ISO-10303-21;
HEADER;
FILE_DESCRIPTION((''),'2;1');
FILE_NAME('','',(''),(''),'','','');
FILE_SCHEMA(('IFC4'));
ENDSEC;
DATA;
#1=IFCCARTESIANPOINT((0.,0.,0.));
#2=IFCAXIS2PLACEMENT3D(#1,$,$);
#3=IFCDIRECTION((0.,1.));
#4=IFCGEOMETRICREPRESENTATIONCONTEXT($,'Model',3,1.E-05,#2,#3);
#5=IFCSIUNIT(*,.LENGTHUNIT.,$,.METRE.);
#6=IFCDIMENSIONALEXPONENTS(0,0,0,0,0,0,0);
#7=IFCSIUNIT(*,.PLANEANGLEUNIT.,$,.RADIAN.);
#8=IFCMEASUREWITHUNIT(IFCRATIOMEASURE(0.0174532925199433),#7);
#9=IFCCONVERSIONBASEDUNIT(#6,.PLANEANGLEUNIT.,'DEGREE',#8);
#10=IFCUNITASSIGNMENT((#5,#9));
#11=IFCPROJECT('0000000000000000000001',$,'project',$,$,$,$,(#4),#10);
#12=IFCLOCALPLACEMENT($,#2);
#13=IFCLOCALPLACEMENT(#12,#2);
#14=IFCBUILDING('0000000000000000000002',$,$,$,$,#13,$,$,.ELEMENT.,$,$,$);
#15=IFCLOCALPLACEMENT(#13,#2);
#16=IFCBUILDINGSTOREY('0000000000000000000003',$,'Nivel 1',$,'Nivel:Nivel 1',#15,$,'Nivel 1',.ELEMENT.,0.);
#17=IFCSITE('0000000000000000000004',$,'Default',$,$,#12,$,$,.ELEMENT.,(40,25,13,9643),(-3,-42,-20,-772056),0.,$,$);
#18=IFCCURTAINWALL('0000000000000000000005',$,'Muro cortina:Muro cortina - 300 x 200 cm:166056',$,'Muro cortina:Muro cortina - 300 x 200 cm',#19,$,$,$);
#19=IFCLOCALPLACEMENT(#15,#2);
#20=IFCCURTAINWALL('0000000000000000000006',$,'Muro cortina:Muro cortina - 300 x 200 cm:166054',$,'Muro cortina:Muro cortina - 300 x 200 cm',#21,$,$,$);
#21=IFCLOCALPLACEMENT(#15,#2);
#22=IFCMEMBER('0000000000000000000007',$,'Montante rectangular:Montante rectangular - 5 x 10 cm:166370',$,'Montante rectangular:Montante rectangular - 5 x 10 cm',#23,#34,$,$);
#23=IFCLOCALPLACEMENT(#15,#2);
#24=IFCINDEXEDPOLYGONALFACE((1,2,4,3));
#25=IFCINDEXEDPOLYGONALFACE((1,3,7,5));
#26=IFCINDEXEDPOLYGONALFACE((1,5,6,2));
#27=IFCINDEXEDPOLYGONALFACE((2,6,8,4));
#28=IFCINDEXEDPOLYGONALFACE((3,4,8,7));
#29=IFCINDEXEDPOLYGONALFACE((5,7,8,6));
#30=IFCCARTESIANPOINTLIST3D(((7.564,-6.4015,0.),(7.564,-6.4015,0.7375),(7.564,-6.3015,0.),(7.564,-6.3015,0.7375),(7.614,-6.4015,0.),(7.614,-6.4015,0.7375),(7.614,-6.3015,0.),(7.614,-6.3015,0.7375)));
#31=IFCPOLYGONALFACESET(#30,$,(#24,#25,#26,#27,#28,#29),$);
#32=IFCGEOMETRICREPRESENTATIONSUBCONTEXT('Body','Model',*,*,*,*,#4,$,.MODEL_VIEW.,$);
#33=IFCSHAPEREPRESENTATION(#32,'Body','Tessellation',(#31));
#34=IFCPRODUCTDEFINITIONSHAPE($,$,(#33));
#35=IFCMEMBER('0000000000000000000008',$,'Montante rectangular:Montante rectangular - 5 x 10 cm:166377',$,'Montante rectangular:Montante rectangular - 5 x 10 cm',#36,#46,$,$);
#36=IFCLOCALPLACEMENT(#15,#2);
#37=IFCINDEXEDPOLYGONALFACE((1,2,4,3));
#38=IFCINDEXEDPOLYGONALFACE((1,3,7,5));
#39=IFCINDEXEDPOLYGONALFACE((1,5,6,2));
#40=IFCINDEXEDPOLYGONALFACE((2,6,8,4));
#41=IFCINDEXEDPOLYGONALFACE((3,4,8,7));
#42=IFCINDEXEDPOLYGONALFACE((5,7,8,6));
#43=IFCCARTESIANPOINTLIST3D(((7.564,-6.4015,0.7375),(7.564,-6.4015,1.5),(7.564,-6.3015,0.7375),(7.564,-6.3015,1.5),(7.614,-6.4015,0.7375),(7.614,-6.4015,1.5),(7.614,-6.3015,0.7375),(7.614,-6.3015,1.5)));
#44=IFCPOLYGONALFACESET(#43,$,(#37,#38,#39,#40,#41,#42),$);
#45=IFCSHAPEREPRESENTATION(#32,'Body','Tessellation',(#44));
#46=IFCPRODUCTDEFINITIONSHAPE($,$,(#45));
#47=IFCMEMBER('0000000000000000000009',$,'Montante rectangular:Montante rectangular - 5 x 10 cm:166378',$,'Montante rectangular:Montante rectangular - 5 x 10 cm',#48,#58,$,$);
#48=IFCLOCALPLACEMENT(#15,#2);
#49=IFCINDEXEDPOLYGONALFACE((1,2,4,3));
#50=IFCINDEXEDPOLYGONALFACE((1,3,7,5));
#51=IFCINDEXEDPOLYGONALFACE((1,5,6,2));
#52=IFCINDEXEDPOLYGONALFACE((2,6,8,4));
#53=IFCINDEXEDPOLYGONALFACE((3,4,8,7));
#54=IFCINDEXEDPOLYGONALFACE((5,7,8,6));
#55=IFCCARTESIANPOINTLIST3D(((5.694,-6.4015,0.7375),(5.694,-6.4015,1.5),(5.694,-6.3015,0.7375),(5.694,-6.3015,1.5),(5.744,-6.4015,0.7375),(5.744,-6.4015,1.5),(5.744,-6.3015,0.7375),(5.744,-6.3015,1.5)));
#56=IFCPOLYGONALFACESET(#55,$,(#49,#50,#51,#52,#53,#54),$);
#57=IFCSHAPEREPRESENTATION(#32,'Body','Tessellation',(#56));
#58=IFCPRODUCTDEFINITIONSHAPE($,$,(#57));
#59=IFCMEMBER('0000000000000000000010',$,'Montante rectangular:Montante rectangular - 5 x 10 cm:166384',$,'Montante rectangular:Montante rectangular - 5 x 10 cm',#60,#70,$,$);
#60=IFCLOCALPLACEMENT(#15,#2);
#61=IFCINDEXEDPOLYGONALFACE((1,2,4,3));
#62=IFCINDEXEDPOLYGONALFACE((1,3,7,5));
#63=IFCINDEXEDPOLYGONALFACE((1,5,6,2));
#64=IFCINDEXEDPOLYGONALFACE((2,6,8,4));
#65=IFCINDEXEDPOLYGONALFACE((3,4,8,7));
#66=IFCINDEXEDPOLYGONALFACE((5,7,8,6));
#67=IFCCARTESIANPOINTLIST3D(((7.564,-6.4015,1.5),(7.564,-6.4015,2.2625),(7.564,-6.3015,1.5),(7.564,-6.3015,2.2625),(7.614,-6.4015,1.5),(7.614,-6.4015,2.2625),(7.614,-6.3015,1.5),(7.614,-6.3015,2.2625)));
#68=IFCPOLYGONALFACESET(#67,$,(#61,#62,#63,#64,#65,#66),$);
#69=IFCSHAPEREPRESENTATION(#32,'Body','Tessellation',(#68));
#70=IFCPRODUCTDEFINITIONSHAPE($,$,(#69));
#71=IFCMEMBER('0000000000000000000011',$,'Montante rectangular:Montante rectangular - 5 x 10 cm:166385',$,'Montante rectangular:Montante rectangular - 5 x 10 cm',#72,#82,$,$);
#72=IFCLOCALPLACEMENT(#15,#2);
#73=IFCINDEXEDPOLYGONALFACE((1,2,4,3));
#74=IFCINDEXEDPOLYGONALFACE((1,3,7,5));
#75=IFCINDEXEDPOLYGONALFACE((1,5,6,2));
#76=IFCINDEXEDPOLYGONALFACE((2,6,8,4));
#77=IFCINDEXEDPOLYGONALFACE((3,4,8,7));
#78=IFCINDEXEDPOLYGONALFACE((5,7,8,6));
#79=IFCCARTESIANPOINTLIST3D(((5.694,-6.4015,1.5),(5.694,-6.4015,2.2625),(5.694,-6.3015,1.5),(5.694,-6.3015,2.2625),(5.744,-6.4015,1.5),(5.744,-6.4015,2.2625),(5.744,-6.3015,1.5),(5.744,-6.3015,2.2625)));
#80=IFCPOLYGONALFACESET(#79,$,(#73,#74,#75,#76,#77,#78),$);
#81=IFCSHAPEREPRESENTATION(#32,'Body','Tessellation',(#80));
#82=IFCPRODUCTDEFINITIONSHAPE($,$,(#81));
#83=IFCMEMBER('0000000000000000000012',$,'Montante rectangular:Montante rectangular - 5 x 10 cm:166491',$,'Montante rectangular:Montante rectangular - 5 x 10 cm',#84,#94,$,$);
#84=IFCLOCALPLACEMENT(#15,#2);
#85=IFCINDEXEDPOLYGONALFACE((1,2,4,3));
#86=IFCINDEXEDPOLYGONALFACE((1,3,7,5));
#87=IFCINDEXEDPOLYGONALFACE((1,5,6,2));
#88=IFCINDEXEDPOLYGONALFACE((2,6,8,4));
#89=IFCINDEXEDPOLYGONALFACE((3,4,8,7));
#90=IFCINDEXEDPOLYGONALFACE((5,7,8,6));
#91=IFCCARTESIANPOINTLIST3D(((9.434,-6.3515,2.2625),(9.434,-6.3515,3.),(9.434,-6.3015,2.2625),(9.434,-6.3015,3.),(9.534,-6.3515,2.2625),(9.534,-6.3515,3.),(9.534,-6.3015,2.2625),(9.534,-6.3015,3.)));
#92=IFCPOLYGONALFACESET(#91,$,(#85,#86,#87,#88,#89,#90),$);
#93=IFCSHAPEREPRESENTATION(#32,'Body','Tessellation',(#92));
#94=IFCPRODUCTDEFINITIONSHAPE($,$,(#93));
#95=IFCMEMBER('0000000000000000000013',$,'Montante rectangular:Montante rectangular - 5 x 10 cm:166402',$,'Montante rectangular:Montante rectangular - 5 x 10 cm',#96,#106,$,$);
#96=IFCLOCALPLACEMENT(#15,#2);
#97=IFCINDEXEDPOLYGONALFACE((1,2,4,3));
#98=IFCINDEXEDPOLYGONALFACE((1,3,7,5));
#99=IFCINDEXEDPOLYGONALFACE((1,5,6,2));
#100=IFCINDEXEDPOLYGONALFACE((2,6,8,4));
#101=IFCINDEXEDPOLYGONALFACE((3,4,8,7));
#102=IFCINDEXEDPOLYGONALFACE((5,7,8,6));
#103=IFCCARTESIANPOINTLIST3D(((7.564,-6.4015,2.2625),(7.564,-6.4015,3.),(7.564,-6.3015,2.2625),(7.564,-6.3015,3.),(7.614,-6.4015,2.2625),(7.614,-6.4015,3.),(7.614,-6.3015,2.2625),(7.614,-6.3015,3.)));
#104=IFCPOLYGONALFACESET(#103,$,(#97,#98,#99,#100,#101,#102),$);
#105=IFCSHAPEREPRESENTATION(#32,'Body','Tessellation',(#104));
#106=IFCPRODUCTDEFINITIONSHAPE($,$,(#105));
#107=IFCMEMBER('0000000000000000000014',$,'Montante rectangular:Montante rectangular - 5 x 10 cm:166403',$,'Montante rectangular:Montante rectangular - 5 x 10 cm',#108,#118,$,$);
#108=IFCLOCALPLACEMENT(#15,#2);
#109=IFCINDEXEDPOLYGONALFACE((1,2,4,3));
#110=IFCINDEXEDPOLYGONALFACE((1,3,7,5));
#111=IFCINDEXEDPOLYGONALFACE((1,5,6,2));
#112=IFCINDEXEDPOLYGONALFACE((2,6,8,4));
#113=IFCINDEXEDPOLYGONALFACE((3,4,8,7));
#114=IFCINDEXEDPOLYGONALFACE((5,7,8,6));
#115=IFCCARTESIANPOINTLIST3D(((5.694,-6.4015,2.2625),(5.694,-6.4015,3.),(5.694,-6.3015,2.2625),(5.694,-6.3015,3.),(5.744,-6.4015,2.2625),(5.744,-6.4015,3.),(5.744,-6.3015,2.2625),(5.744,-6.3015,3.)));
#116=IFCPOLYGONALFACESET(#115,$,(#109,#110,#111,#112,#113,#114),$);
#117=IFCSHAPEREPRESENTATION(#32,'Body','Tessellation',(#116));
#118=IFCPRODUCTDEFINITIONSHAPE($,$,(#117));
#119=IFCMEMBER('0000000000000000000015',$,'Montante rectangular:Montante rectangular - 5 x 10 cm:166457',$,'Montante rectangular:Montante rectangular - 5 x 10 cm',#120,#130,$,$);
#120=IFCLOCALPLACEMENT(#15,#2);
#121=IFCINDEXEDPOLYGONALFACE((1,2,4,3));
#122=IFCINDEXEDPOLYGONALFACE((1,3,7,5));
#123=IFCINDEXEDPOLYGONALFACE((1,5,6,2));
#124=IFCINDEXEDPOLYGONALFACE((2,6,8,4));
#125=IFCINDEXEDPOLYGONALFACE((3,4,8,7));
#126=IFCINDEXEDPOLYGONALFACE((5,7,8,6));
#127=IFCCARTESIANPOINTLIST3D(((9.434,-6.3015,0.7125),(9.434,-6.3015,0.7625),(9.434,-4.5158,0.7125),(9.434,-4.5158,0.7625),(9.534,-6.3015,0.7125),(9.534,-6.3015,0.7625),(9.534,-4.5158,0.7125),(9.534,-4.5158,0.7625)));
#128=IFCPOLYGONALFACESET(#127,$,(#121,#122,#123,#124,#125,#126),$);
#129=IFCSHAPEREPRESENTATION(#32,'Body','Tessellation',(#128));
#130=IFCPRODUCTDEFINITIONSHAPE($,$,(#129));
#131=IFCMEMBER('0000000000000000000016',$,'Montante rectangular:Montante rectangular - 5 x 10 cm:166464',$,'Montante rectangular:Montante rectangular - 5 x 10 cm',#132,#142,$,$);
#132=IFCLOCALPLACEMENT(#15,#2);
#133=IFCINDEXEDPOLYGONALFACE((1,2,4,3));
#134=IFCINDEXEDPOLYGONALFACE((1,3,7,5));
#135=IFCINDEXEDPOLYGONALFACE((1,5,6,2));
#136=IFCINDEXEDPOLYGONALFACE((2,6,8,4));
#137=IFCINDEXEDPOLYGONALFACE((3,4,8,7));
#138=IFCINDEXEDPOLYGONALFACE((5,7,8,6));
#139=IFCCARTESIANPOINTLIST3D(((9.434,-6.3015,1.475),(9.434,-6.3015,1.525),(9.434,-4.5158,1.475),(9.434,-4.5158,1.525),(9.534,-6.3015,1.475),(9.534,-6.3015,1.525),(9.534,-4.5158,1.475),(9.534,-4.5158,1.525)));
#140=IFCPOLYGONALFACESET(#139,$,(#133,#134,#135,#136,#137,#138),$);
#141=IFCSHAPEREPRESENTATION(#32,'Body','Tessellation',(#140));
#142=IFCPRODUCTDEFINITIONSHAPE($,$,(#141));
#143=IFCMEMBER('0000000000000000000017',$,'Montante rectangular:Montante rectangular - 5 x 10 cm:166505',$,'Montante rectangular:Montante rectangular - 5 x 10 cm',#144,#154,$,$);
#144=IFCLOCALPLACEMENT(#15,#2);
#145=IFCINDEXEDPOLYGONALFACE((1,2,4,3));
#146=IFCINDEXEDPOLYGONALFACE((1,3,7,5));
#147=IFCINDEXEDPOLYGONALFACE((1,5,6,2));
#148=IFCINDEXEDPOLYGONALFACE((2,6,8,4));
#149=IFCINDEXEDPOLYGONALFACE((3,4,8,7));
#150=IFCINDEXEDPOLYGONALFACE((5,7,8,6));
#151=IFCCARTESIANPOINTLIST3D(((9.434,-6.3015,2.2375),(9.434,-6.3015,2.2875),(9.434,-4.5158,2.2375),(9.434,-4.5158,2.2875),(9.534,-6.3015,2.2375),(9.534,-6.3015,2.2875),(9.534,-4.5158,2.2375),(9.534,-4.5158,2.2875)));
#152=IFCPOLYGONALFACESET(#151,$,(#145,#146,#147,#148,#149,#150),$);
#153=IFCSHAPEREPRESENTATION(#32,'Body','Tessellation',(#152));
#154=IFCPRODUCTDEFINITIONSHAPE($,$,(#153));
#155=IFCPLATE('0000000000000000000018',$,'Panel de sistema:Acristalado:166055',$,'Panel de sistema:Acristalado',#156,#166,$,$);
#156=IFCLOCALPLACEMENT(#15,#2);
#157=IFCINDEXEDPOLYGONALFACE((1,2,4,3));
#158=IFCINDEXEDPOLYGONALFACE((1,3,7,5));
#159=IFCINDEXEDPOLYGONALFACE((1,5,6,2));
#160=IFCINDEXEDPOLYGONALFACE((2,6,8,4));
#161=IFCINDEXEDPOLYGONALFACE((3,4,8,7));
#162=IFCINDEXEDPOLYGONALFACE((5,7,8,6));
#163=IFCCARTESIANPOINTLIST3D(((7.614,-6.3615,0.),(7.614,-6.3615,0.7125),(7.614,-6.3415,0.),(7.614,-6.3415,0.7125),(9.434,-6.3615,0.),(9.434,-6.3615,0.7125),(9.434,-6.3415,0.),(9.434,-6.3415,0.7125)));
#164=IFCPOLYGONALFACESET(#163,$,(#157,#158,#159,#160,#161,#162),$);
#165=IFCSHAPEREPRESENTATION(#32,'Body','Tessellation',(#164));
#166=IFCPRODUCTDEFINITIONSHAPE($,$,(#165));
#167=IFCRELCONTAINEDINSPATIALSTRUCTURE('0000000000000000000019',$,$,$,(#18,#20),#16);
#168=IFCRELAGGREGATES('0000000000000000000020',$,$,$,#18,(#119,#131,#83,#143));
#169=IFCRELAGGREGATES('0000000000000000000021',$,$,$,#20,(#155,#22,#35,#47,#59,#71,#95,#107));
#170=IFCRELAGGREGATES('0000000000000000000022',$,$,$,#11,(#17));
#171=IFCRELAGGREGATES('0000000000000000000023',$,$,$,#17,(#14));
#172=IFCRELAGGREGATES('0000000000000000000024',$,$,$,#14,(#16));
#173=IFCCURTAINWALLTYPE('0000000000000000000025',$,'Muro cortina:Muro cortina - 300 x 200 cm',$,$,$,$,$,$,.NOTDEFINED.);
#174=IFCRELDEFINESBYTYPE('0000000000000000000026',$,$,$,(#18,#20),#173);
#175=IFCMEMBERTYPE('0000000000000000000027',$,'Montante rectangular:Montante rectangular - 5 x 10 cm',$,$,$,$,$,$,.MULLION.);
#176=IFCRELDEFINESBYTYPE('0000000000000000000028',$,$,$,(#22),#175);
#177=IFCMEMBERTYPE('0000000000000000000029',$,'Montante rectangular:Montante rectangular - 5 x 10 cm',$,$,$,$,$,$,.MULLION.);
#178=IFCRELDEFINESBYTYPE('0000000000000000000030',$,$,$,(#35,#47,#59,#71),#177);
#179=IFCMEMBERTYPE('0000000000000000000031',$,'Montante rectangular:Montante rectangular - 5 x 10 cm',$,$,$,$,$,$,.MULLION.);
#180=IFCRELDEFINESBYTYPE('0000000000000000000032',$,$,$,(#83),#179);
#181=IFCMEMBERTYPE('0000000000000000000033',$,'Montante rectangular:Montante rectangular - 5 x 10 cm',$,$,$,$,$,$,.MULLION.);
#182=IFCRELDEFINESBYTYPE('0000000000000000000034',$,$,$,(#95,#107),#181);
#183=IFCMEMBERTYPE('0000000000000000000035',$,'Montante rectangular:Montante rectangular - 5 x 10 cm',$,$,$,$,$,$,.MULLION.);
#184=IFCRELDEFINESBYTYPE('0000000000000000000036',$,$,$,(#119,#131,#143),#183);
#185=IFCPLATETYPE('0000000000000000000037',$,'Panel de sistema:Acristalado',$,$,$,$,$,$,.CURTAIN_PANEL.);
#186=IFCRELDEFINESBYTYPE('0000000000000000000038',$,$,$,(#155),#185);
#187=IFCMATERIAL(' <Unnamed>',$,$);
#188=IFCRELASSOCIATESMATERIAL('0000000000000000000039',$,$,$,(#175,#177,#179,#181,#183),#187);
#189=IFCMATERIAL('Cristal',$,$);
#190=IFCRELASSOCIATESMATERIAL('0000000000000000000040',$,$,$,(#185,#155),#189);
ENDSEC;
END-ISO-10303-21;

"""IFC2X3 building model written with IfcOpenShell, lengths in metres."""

from ifc_helpers import new_model, entity, si_unit, converted_unit, direction, frame, origin, origin_2d_with_axis, place, context, subcontext, project, spatial, rectangle, extrude, source, transform, mapped, material, type_object, type_shapes, element, aggregate, save


model = new_model("IFC2X3")

# Units and contexts
model_context = context("Model", 3, precision=1e-05, world=origin(), true_north=direction((0.0, 1.0)))
body_context = subcontext(model_context, "Body", "Model", "MODEL_VIEW")
ifc_project = project(units=[si_unit("LENGTHUNIT", "METRE"), converted_unit("PLANEANGLEUNIT", "DEGREE", entity("IfcRatioMeasure", 0.0174532925199433), si_unit("PLANEANGLEUNIT", "RADIAN"), dimensions=[0, 0, 0, 0, 0, 0, 0])], contexts=[model_context])

# Site, building, storey
site_placement = place(None, origin())
site = spatial("IfcSite", under=ifc_project, at=site_placement, Name="Default", CompositionType="ELEMENT", RefLatitude=(40, 25, 13, 9643), RefLongitude=(-3, -42, -20, -772056), RefElevation=0.0)
building_placement = place(site_placement, origin())
building = spatial("IfcBuilding", under=site, at=building_placement, CompositionType="ELEMENT")
storey_placement = place(building_placement, origin())
storey = spatial("IfcBuildingStorey", under=building, at=storey_placement, Name="Nivel 1", ObjectType="Nivel:Nivel 1", LongName="Nivel 1", CompositionType="ELEMENT", Elevation=0.0)

# Curtain walls, members
curtain_wall_type = type_object("IfcCurtainWallType", Name="Muro cortina:Muro cortina - 300 x 200 cm", PredefinedType="NOTDEFINED")
curtain_wall_1_placement = place(storey_placement, origin())
curtain_wall_1 = element("IfcCurtainWall", 1, at=curtain_wall_1_placement, inside=storey, type_object=curtain_wall_type, Name="Muro cortina:Muro cortina - 300 x 200 cm:166056", ObjectType="Muro cortina:Muro cortina - 300 x 200 cm")
ifc_material_1 = material(Name=" <Unnamed>")
curtain_wall_2_placement = place(storey_placement, origin())
curtain_wall_2 = element("IfcCurtainWall", 2, at=curtain_wall_2_placement, inside=storey, type_object=curtain_wall_type, Name="Muro cortina:Muro cortina - 300 x 200 cm:166054", ObjectType="Muro cortina:Muro cortina - 300 x 200 cm")
member_type_1 = type_object("IfcMemberType", Name="Montante rectangular:Montante rectangular - 5 x 10 cm", PredefinedType="MULLION", material=ifc_material_1)
shared_shape_1 = source(origin(), body_context, "Body", "SweptSolid", [
    extrude(rectangle(XDim=0.1, YDim=0.05, at=origin_2d_with_axis()), frame((0.0, 0.0, -0.7375), z_axis=(0.0, 0.0, 1.0), x_axis=(0.0, -1.0, 0.0)), (0.0, 0.0, 1.0), 0.7375),
])
type_shapes(member_type_1, [shared_shape_1])
member_1_placement = place(storey_placement, frame((7.589, -6.3515, 0.0), z_axis=(0.0, 0.0, -1.0), x_axis=(-1.0, 0.0, 0.0)))
member_1 = element("IfcMember", 3, at=member_1_placement, type_object=member_type_1, Name="Montante rectangular:Montante rectangular - 5 x 10 cm:166370", ObjectType="Montante rectangular:Montante rectangular - 5 x 10 cm", context=body_context, shape_type="MappedRepresentation", body=[
    mapped(shared_shape_1, transform((0.0, 0.0, 0.0), scale=1.0)),
])
member_type_2 = type_object("IfcMemberType", Name="Montante rectangular:Montante rectangular - 5 x 10 cm", PredefinedType="MULLION", material=ifc_material_1)
shared_shape_2 = source(origin(), body_context, "Body", "SweptSolid", [
    extrude(rectangle(XDim=0.1, YDim=0.05, at=origin_2d_with_axis()), frame((0.0, 0.0, -0.7625), z_axis=(0.0, 0.0, 1.0), x_axis=(0.0, -1.0, 0.0)), (0.0, 0.0, 1.0), 0.7625),
])
type_shapes(member_type_2, [shared_shape_2])
member_2_placement = place(storey_placement, frame((7.589, -6.3515, 0.7375), z_axis=(0.0, 0.0, -1.0), x_axis=(-1.0, 0.0, 0.0)))
member_2 = element("IfcMember", 4, at=member_2_placement, type_object=member_type_2, Name="Montante rectangular:Montante rectangular - 5 x 10 cm:166377", ObjectType="Montante rectangular:Montante rectangular - 5 x 10 cm", context=body_context, shape_type="MappedRepresentation", body=[
    mapped(shared_shape_2, transform((0.0, 0.0, 0.0), scale=1.0)),
])
member_3_placement = place(storey_placement, frame((5.719, -6.3515, 0.7375), z_axis=(0.0, 0.0, -1.0), x_axis=(-1.0, 0.0, 0.0)))
member_3 = element("IfcMember", 5, at=member_3_placement, type_object=member_type_2, Name="Montante rectangular:Montante rectangular - 5 x 10 cm:166378", ObjectType="Montante rectangular:Montante rectangular - 5 x 10 cm", context=body_context, shape_type="MappedRepresentation", body=[
    mapped(shared_shape_2, transform((0.0, 0.0, 0.0), scale=1.0)),
])
member_4_placement = place(storey_placement, frame((7.589, -6.3515, 1.5), z_axis=(0.0, 0.0, -1.0), x_axis=(-1.0, 0.0, 0.0)))
member_4 = element("IfcMember", 6, at=member_4_placement, type_object=member_type_2, Name="Montante rectangular:Montante rectangular - 5 x 10 cm:166384", ObjectType="Montante rectangular:Montante rectangular - 5 x 10 cm", context=body_context, shape_type="MappedRepresentation", body=[
    mapped(shared_shape_2, transform((0.0, 0.0, 0.0), scale=1.0)),
])
member_5_placement = place(storey_placement, frame((5.719, -6.3515, 1.5), z_axis=(0.0, 0.0, -1.0), x_axis=(-1.0, 0.0, 0.0)))
member_5 = element("IfcMember", 7, at=member_5_placement, type_object=member_type_2, Name="Montante rectangular:Montante rectangular - 5 x 10 cm:166385", ObjectType="Montante rectangular:Montante rectangular - 5 x 10 cm", context=body_context, shape_type="MappedRepresentation", body=[
    mapped(shared_shape_2, transform((0.0, 0.0, 0.0), scale=1.0)),
])

# Members
member_type_3 = type_object("IfcMemberType", Name="Montante rectangular:Montante rectangular - 5 x 10 cm", PredefinedType="MULLION", material=ifc_material_1)
shared_shape_3 = source(origin(), body_context, "Body", "SweptSolid", [
    extrude(rectangle(XDim=0.1, YDim=0.05, at=origin_2d_with_axis()), frame((-0.025, 0.0, -0.7375), z_axis=(0.0, 0.0, 1.0), x_axis=(0.0, -1.0, 0.0)), (0.0, 0.0, 1.0), 0.7375),
])
type_shapes(member_type_3, [shared_shape_3])
member_6_placement = place(storey_placement, frame((9.484, -6.3515, 2.2625), z_axis=(0.0, 0.0, -1.0), x_axis=(0.0, -1.0, 0.0)))
member_6 = element("IfcMember", 8, at=member_6_placement, type_object=member_type_3, Name="Montante rectangular:Montante rectangular - 5 x 10 cm:166491", ObjectType="Montante rectangular:Montante rectangular - 5 x 10 cm", context=body_context, shape_type="MappedRepresentation", body=[
    mapped(shared_shape_3, transform((0.0, 0.0, 0.0), scale=1.0)),
])
member_type_4 = type_object("IfcMemberType", Name="Montante rectangular:Montante rectangular - 5 x 10 cm", PredefinedType="MULLION", material=ifc_material_1)
shared_shape_4 = source(origin(), body_context, "Body", "SweptSolid", [
    extrude(rectangle(XDim=0.1, YDim=0.05, at=origin_2d_with_axis()), frame((0.0, 0.0, -0.7375), z_axis=(0.0, 0.0, 1.0), x_axis=(0.0, -1.0, 0.0)), (0.0, 0.0, 1.0), 0.7375),
])
type_shapes(member_type_4, [shared_shape_4])
member_7_placement = place(storey_placement, frame((7.589, -6.3515, 2.2625), z_axis=(0.0, 0.0, -1.0), x_axis=(-1.0, 0.0, 0.0)))
member_7 = element("IfcMember", 9, at=member_7_placement, type_object=member_type_4, Name="Montante rectangular:Montante rectangular - 5 x 10 cm:166402", ObjectType="Montante rectangular:Montante rectangular - 5 x 10 cm", context=body_context, shape_type="MappedRepresentation", body=[
    mapped(shared_shape_4, transform((0.0, 0.0, 0.0), scale=1.0)),
])
member_8_placement = place(storey_placement, frame((5.719, -6.3515, 2.2625), z_axis=(0.0, 0.0, -1.0), x_axis=(-1.0, 0.0, 0.0)))
member_8 = element("IfcMember", 10, at=member_8_placement, type_object=member_type_4, Name="Montante rectangular:Montante rectangular - 5 x 10 cm:166403", ObjectType="Montante rectangular:Montante rectangular - 5 x 10 cm", context=body_context, shape_type="MappedRepresentation", body=[
    mapped(shared_shape_4, transform((0.0, 0.0, 0.0), scale=1.0)),
])
member_type_5 = type_object("IfcMemberType", Name="Montante rectangular:Montante rectangular - 5 x 10 cm", PredefinedType="MULLION", material=ifc_material_1)
shared_shape_5 = source(origin(), body_context, "Body", "SweptSolid", [
    extrude(rectangle(XDim=0.1, YDim=0.05, at=origin_2d_with_axis()), frame((0.0, 0.0, -1.7857), z_axis=(0.0, 0.0, 1.0), x_axis=(0.0, -1.0, 0.0)), (0.0, 0.0, 1.0), 1.7857),
])
type_shapes(member_type_5, [shared_shape_5])
member_9_placement = place(storey_placement, frame((9.484, -6.3015, 0.7375), z_axis=(0.0, -1.0, 0.0), x_axis=(0.0, 0.0, 1.0)))
member_9 = element("IfcMember", 11, at=member_9_placement, type_object=member_type_5, Name="Montante rectangular:Montante rectangular - 5 x 10 cm:166457", ObjectType="Montante rectangular:Montante rectangular - 5 x 10 cm", context=body_context, shape_type="MappedRepresentation", body=[
    mapped(shared_shape_5, transform((0.0, 0.0, 0.0), scale=1.0)),
])
member_10_placement = place(storey_placement, frame((9.484, -6.3015, 1.5), z_axis=(0.0, -1.0, 0.0), x_axis=(0.0, 0.0, 1.0)))
member_10 = element("IfcMember", 12, at=member_10_placement, type_object=member_type_5, Name="Montante rectangular:Montante rectangular - 5 x 10 cm:166464", ObjectType="Montante rectangular:Montante rectangular - 5 x 10 cm", context=body_context, shape_type="MappedRepresentation", body=[
    mapped(shared_shape_5, transform((0.0, 0.0, 0.0), scale=1.0)),
])
member_11_placement = place(storey_placement, frame((9.484, -6.3015, 2.2625), z_axis=(0.0, -1.0, 0.0), x_axis=(0.0, 0.0, 1.0)))
member_11 = element("IfcMember", 13, at=member_11_placement, type_object=member_type_5, Name="Montante rectangular:Montante rectangular - 5 x 10 cm:166505", ObjectType="Montante rectangular:Montante rectangular - 5 x 10 cm", context=body_context, shape_type="MappedRepresentation", body=[
    mapped(shared_shape_5, transform((0.0, 0.0, 0.0), scale=1.0)),
])
aggregate(curtain_wall_1, [member_9, member_10, member_6, member_11])

# Plate
ifc_material_2 = material(Name="Cristal")
plate_type = type_object("IfcPlateType", Name="Panel de sistema:Acristalado", PredefinedType="CURTAIN_PANEL", material=ifc_material_2)
shared_shape_6 = source(origin(), body_context, "Body", "SweptSolid", [
    extrude(rectangle(XDim=0.02, YDim=1.82, at=origin_2d_with_axis()), frame((0.0, 0.0, 0.0), z_axis=(0.0, 0.0, 1.0), x_axis=(0.0, 1.0, 0.0)), (0.0, 0.0, 1.0), 0.7125),
])
type_shapes(plate_type, [shared_shape_6])
plate_1_placement = place(curtain_wall_2_placement, frame((8.524, -6.3515, 0.0), z_axis=(0.0, 0.0, 1.0), x_axis=(-1.0, 0.0, 0.0)))
plate_1 = element("IfcPlate", 14, at=plate_1_placement, type_object=plate_type, material=ifc_material_2, Name="Panel de sistema:Acristalado:166055", ObjectType="Panel de sistema:Acristalado", context=body_context, shape_type="MappedRepresentation", body=[
    mapped(shared_shape_6, transform((0.0, 0.0, 0.0), scale=1.0)),
])
aggregate(curtain_wall_2, [plate_1, member_1, member_2, member_3, member_4, member_5, member_7, member_8])

save(model, "model.ifc")
